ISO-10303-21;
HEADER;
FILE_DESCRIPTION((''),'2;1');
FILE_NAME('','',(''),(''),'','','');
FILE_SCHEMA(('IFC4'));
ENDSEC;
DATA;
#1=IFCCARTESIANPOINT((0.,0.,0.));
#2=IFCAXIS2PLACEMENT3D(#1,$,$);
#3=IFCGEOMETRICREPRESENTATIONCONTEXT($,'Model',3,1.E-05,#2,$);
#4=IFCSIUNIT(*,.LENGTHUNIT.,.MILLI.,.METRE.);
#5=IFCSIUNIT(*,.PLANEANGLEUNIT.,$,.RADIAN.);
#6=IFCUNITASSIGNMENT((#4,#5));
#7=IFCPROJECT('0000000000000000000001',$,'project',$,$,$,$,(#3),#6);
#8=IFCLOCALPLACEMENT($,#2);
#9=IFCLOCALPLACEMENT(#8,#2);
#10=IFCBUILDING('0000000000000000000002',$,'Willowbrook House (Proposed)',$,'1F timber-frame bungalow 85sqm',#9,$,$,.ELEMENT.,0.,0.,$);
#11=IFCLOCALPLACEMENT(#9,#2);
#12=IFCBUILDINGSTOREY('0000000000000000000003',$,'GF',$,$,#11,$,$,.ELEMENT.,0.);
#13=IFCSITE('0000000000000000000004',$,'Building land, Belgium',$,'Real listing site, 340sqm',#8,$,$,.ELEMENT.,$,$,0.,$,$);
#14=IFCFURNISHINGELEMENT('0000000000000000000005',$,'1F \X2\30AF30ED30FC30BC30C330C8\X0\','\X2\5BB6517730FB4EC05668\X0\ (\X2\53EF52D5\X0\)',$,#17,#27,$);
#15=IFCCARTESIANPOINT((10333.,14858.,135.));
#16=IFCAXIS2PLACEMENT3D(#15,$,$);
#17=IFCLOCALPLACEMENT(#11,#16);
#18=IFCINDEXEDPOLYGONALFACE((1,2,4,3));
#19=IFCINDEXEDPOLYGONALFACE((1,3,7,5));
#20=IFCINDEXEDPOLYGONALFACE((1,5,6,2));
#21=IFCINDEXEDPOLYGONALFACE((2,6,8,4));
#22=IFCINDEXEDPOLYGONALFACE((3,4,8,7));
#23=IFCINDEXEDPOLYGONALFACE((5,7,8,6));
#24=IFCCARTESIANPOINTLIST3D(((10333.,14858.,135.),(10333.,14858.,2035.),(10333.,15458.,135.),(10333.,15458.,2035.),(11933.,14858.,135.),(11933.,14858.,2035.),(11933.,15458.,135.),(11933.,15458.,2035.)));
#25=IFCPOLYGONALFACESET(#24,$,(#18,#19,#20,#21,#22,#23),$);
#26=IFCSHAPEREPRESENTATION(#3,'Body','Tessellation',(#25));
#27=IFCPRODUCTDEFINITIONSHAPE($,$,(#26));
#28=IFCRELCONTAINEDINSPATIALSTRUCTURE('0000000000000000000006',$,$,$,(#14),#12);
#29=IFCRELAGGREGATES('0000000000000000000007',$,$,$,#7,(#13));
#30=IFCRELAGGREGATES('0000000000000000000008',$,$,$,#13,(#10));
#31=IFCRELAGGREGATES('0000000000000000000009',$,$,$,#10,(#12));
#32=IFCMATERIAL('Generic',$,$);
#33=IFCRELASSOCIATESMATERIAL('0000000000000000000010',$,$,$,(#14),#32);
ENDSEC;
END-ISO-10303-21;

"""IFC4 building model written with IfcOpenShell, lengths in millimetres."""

from ifc_helpers import new_model, si_unit, frame, frame_2d, origin, place, context, project, spatial, rectangle, extrude, material, element, save


model = new_model("IFC4")

# Units and contexts
model_context = context("Model", 3, precision=1e-05, world=origin())
ifc_project = project(units=[si_unit("LENGTHUNIT", "METRE", prefix="MILLI"), si_unit("PLANEANGLEUNIT", "RADIAN")], contexts=[model_context])

# Site, building, storey
site_placement = place(None, origin())
site = spatial("IfcSite", under=ifc_project, at=site_placement, Name="Building land, Belgium", ObjectType="Real listing site, 340sqm", CompositionType="ELEMENT", RefElevation=0.0)
building_placement = place(site_placement, origin())
building = spatial("IfcBuilding", under=site, at=building_placement, Name="Willowbrook House (Proposed)", ObjectType="1F timber-frame bungalow 85sqm", CompositionType="ELEMENT", ElevationOfRefHeight=0.0, ElevationOfTerrain=0.0)
storey_placement = place(building_placement, origin())
storey = spatial("IfcBuildingStorey", under=building, at=storey_placement, Name="GF", CompositionType="ELEMENT", Elevation=0.0)

# Shared definitions
ifc_material_1 = material(Name="Generic")

# Furnishing element
furnishing_placement = place(storey_placement, frame((10333.0, 14858.0, 135.0)))
element("IfcFurnishingElement", 1, at=furnishing_placement, inside=storey, material=ifc_material_1, Name="1F クローゼット", Description="家具・什器 (可動)", context=model_context, shape_type="SweptSolid", body=[
    extrude(rectangle(XDim=1600.0, YDim=600.0, at=frame_2d((800.0, 300.0))), frame((10333.0, 14858.0, 135.0)), (0.0, 0.0, 1.0), 1900.0),
])

save(model, "model.ifc")
